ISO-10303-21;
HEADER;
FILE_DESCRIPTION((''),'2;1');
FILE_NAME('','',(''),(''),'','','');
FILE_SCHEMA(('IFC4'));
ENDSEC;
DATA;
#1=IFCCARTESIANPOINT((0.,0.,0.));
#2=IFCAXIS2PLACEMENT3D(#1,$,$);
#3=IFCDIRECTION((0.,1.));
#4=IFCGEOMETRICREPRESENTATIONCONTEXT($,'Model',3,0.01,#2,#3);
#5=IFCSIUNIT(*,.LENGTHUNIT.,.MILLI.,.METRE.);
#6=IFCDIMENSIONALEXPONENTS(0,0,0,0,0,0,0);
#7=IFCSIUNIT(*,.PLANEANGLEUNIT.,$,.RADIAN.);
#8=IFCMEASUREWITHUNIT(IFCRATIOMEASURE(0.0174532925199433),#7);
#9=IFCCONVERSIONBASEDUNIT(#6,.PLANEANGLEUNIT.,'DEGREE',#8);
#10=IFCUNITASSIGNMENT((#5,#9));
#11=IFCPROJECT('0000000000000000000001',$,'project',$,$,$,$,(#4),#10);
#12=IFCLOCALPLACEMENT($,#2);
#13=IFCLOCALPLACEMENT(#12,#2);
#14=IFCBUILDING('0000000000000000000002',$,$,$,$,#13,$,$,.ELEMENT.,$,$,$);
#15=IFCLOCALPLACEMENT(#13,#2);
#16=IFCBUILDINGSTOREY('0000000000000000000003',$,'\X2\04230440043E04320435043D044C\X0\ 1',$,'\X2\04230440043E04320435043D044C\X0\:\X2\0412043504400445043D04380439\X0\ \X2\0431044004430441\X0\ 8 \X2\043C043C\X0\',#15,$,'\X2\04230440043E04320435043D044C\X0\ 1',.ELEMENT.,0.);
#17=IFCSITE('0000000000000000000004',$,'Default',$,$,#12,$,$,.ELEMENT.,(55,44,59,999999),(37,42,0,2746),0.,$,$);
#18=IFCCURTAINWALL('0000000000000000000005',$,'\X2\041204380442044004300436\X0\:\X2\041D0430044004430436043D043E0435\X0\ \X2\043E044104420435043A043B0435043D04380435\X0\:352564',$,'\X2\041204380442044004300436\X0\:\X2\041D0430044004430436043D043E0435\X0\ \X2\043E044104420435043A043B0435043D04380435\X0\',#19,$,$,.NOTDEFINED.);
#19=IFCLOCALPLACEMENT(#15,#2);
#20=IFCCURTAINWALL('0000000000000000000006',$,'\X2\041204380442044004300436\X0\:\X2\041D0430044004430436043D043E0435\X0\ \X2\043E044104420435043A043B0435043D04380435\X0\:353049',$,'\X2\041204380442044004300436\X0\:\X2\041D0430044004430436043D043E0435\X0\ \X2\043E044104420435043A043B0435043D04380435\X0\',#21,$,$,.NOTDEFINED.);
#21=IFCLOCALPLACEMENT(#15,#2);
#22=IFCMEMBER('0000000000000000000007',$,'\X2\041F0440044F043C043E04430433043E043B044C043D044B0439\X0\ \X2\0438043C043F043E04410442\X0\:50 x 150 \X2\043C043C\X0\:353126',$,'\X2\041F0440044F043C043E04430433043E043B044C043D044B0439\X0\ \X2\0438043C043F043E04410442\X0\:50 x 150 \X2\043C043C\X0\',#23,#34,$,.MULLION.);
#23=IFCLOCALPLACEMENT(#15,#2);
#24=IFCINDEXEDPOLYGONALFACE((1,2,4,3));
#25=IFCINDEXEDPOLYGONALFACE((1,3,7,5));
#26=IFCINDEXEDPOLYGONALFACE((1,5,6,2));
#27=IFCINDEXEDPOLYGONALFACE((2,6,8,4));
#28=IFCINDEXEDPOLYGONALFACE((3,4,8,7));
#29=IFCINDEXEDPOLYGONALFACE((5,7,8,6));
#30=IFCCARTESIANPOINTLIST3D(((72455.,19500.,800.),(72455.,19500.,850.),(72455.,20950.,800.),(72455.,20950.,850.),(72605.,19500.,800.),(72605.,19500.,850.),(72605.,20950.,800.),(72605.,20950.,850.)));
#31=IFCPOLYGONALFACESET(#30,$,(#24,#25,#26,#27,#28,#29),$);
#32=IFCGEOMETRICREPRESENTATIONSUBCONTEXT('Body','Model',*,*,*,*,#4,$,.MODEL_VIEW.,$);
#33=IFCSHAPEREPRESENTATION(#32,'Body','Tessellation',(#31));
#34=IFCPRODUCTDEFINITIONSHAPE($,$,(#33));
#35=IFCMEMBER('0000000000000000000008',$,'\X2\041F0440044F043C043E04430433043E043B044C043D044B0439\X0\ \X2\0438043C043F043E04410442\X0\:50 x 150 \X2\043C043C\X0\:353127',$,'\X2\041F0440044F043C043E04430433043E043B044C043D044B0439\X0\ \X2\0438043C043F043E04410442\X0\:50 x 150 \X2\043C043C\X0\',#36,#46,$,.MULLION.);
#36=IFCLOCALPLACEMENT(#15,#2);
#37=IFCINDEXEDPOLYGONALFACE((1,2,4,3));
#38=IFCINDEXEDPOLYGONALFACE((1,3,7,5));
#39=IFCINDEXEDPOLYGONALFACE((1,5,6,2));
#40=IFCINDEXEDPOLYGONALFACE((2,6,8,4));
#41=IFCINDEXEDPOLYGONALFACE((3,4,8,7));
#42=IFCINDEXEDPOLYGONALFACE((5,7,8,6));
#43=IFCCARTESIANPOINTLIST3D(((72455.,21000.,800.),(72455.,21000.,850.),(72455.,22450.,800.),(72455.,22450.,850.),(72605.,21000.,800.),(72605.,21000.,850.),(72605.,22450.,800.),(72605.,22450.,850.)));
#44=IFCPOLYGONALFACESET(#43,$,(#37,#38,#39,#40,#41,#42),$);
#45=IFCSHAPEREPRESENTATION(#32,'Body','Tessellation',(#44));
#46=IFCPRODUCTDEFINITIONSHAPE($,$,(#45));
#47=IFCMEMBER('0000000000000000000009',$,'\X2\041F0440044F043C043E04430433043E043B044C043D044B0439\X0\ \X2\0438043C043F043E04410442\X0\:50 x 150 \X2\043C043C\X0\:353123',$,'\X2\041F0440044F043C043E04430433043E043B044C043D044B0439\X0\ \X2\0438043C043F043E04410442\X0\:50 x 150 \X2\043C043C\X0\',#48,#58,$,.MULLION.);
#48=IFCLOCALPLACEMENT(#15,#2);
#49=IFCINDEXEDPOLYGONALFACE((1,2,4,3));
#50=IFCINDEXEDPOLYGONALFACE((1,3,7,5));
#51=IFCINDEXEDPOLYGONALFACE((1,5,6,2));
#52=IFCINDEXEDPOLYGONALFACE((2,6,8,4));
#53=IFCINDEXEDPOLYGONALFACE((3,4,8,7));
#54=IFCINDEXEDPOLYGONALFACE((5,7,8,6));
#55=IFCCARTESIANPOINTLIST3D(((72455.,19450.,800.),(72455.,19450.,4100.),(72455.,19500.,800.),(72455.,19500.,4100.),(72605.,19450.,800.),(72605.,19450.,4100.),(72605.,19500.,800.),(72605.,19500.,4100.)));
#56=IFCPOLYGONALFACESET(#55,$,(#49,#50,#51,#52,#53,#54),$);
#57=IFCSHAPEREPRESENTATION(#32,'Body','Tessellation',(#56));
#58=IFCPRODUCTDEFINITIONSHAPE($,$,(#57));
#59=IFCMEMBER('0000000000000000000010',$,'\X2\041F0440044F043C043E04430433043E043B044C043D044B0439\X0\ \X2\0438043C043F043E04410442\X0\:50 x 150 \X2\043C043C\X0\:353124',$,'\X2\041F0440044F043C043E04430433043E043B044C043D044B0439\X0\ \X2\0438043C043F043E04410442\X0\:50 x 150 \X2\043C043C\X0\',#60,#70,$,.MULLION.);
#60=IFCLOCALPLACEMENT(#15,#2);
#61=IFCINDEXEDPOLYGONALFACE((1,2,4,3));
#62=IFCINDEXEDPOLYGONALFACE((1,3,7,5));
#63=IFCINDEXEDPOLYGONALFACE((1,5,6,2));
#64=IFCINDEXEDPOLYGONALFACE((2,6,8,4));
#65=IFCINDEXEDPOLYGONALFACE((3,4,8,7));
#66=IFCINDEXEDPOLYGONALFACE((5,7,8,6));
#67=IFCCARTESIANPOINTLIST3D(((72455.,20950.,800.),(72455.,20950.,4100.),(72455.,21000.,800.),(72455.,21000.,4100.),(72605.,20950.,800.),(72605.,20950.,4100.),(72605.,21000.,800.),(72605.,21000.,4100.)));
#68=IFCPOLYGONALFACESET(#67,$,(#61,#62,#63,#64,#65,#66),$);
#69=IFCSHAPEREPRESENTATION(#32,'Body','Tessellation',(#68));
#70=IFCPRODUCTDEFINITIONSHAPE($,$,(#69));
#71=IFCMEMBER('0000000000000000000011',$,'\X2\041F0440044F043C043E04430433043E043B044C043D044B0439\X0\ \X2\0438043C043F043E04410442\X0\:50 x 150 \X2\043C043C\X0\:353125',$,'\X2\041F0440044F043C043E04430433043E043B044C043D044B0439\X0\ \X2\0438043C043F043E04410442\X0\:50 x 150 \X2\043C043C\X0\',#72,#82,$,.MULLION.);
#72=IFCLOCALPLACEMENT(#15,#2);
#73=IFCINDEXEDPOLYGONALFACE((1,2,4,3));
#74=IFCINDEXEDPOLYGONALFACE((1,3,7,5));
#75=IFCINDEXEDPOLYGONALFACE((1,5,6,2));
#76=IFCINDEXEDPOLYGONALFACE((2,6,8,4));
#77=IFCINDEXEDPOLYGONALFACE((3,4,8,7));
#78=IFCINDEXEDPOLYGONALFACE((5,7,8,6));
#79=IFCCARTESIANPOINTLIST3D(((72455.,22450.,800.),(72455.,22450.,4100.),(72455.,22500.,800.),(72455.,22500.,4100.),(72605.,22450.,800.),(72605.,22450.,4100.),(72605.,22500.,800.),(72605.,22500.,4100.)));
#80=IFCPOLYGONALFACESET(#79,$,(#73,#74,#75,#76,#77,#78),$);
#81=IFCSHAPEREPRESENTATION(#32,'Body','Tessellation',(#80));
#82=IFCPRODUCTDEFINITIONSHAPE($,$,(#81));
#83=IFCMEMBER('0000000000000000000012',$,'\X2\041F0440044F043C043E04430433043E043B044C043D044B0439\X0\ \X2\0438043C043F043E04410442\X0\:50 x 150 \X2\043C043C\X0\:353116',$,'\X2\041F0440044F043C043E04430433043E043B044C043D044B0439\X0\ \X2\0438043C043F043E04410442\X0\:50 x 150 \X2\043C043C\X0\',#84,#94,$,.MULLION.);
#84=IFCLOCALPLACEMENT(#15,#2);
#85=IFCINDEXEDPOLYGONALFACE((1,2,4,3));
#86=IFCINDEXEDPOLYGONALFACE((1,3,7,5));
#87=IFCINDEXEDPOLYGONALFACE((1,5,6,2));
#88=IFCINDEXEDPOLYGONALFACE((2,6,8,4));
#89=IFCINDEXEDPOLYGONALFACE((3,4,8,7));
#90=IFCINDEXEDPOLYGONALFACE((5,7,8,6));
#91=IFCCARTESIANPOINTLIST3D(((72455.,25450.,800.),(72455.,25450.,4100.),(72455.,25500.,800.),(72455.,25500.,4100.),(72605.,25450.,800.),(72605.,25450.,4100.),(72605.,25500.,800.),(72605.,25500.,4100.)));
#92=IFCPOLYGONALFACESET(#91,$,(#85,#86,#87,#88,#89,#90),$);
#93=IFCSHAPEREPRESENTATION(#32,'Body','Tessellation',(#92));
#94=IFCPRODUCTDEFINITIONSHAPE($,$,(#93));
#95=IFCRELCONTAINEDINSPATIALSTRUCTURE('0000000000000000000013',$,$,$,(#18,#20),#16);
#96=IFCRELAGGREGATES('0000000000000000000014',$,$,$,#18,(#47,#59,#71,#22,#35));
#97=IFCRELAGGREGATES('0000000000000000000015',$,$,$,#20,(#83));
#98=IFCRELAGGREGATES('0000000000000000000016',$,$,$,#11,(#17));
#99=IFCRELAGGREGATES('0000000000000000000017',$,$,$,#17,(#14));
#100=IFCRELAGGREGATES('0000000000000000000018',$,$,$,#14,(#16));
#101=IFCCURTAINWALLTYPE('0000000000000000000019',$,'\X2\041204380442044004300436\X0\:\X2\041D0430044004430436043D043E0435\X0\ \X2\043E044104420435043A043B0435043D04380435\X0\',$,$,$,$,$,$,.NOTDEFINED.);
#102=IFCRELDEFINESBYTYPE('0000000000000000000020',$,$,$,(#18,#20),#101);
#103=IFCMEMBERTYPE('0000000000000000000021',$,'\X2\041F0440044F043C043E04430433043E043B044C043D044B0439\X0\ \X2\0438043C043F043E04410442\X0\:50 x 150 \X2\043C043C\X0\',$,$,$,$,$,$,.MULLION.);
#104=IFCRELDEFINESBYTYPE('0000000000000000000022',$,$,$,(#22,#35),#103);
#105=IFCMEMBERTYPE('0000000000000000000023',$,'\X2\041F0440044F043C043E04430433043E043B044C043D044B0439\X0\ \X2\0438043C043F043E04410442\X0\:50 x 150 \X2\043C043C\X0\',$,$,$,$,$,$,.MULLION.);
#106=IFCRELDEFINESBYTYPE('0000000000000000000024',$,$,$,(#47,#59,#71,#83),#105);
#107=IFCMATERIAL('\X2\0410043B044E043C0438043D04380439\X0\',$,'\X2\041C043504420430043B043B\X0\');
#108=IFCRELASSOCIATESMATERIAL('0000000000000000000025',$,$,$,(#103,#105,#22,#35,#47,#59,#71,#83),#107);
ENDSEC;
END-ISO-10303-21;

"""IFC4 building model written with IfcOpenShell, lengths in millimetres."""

from ifc_helpers import new_model, entity, si_unit, converted_unit, direction, frame, origin, origin_2d_with_axis, place, context, subcontext, project, spatial, rectangle, extrude, source, transform, mapped, material, material_profile, profile_set, profile_usage, type_object, type_shapes, element, aggregate, save


model = new_model("IFC4")

# Units and contexts
model_context = context("Model", 3, precision=0.01, world=origin(), true_north=direction((0.0, 1.0)))
body_context = subcontext(model_context, "Body", "Model", "MODEL_VIEW")
ifc_project = project(units=[si_unit("LENGTHUNIT", "METRE", prefix="MILLI"), converted_unit("PLANEANGLEUNIT", "DEGREE", entity("IfcRatioMeasure", 0.0174532925199433), si_unit("PLANEANGLEUNIT", "RADIAN"), dimensions=[0, 0, 0, 0, 0, 0, 0])], contexts=[model_context])

# Site, building, storey
site_placement = place(None, origin())
site = spatial("IfcSite", under=ifc_project, at=site_placement, Name="Default", CompositionType="ELEMENT", RefLatitude=(55, 44, 59, 999999), RefLongitude=(37, 42, 0, 2746), RefElevation=0.0)
building_placement = place(site_placement, origin())
building = spatial("IfcBuilding", under=site, at=building_placement, CompositionType="ELEMENT")
storey_placement = place(building_placement, origin())
storey = spatial("IfcBuildingStorey", under=building, at=storey_placement, Name="Уровень 1", ObjectType="Уровень:Верхний брус 8 мм", LongName="Уровень 1", CompositionType="ELEMENT", Elevation=0.0)

# Shared definitions
curtain_wall_type = type_object("IfcCurtainWallType", Name="Витраж:Наружное остекление", PredefinedType="NOTDEFINED")
ifc_material_1 = material(Name="Алюминий", Category="Металл")
ifc_material_profile = material_profile(ifc_material_1, rectangle(XDim=150.0, YDim=50.0, at=origin_2d_with_axis()), Name="50 x 150 мм")
ifc_profile_set = profile_set([ifc_material_profile], Name="50 x 150 мм")

# Curtain wall
curtain_wall_1_placement = place(storey_placement, origin())
curtain_wall_1 = element("IfcCurtainWall", 1, at=curtain_wall_1_placement, inside=storey, type_object=curtain_wall_type, Name="Витраж:Наружное остекление:352564", ObjectType="Витраж:Наружное остекление", PredefinedType="NOTDEFINED")

# Curtain wall
curtain_wall_2_placement = place(storey_placement, origin())
curtain_wall_2 = element("IfcCurtainWall", 2, at=curtain_wall_2_placement, inside=storey, type_object=curtain_wall_type, Name="Витраж:Наружное остекление:353049", ObjectType="Витраж:Наружное остекление", PredefinedType="NOTDEFINED")

# Members
ifc_profile_usage_1 = profile_usage(ifc_profile_set)
member_type_1 = type_object("IfcMemberType", Name="Прямоугольный импост:50 x 150 мм", PredefinedType="MULLION", material=ifc_profile_set)
shared_shape_1 = source(origin(), body_context, "Body", "SweptSolid", [
    extrude(rectangle(XDim=150.0, YDim=50.0, at=origin_2d_with_axis()), frame((-25.0, 0.0, -1450.0), z_axis=(0.0, 0.0, 1.0), x_axis=(0.0, -1.0, 0.0)), (0.0, 0.0, 1.0), 1450.0),
])
type_shapes(member_type_1, [shared_shape_1])
member_1_placement = place(storey_placement, frame((72530.0, 19500.0, 800.0), z_axis=(0.0, -1.0, 0.0), x_axis=(0.0, 0.0, -1.0)))
member_1 = element("IfcMember", 3, at=member_1_placement, type_object=member_type_1, material=ifc_profile_usage_1, Name="Прямоугольный импост:50 x 150 мм:353126", ObjectType="Прямоугольный импост:50 x 150 мм", PredefinedType="MULLION", context=body_context, shape_type="MappedRepresentation", body=[
    mapped(shared_shape_1, transform((0.0, 0.0, 0.0), scale=1.0)),
])
ifc_profile_usage_2 = profile_usage(ifc_profile_set)
member_2_placement = place(storey_placement, frame((72530.0, 21000.0, 800.0), z_axis=(0.0, -1.0, 0.0), x_axis=(0.0, 0.0, -1.0)))
member_2 = element("IfcMember", 4, at=member_2_placement, type_object=member_type_1, material=ifc_profile_usage_2, Name="Прямоугольный импост:50 x 150 мм:353127", ObjectType="Прямоугольный импост:50 x 150 мм", PredefinedType="MULLION", context=body_context, shape_type="MappedRepresentation", body=[
    mapped(shared_shape_1, transform((0.0, 0.0, 0.0), scale=1.0)),
])
ifc_profile_usage_3 = profile_usage(ifc_profile_set)
member_type_2 = type_object("IfcMemberType", Name="Прямоугольный импост:50 x 150 мм", PredefinedType="MULLION", material=ifc_profile_set)
shared_shape_2 = source(origin(), body_context, "Body", "SweptSolid", [
    extrude(rectangle(XDim=150.0, YDim=50.0, at=origin_2d_with_axis()), frame((0.0, 0.0, -3300.0), z_axis=(0.0, 0.0, 1.0), x_axis=(0.0, -1.0, 0.0)), (0.0, 0.0, 1.0), 3300.0),
])
type_shapes(member_type_2, [shared_shape_2])
member_3_placement = place(storey_placement, frame((72530.0, 19475.0, 800.0), z_axis=(0.0, 0.0, -1.0), x_axis=(0.0, 1.0, 0.0)))
member_3 = element("IfcMember", 5, at=member_3_placement, type_object=member_type_2, material=ifc_profile_usage_3, Name="Прямоугольный импост:50 x 150 мм:353123", ObjectType="Прямоугольный импост:50 x 150 мм", PredefinedType="MULLION", context=body_context, shape_type="MappedRepresentation", body=[
    mapped(shared_shape_2, transform((0.0, 0.0, 0.0), scale=1.0)),
])
ifc_profile_usage_4 = profile_usage(ifc_profile_set)
member_4_placement = place(storey_placement, frame((72530.0, 20975.0, 800.0), z_axis=(0.0, 0.0, -1.0), x_axis=(0.0, 1.0, 0.0)))
member_4 = element("IfcMember", 6, at=member_4_placement, type_object=member_type_2, material=ifc_profile_usage_4, Name="Прямоугольный импост:50 x 150 мм:353124", ObjectType="Прямоугольный импост:50 x 150 мм", PredefinedType="MULLION", context=body_context, shape_type="MappedRepresentation", body=[
    mapped(shared_shape_2, transform((0.0, 0.0, 0.0), scale=1.0)),
])
ifc_profile_usage_5 = profile_usage(ifc_profile_set)
member_5_placement = place(storey_placement, frame((72530.0, 22475.0, 800.0), z_axis=(0.0, 0.0, -1.0), x_axis=(0.0, 1.0, 0.0)))
member_5 = element("IfcMember", 7, at=member_5_placement, type_object=member_type_2, material=ifc_profile_usage_5, Name="Прямоугольный импост:50 x 150 мм:353125", ObjectType="Прямоугольный импост:50 x 150 мм", PredefinedType="MULLION", context=body_context, shape_type="MappedRepresentation", body=[
    mapped(shared_shape_2, transform((0.0, 0.0, 0.0), scale=1.0)),
])
ifc_profile_usage_6 = profile_usage(ifc_profile_set)
member_6_placement = place(storey_placement, frame((72530.0, 25475.0, 800.0), z_axis=(0.0, 0.0, -1.0), x_axis=(0.0, 1.0, 0.0)))
member_6 = element("IfcMember", 8, at=member_6_placement, type_object=member_type_2, material=ifc_profile_usage_6, Name="Прямоугольный импост:50 x 150 мм:353116", ObjectType="Прямоугольный импост:50 x 150 мм", PredefinedType="MULLION", context=body_context, shape_type="MappedRepresentation", body=[
    mapped(shared_shape_2, transform((0.0, 0.0, 0.0), scale=1.0)),
])

aggregate(curtain_wall_1, [member_3, member_4, member_5, member_1, member_2])
aggregate(curtain_wall_2, [member_6])

save(model, "model.ifc")
